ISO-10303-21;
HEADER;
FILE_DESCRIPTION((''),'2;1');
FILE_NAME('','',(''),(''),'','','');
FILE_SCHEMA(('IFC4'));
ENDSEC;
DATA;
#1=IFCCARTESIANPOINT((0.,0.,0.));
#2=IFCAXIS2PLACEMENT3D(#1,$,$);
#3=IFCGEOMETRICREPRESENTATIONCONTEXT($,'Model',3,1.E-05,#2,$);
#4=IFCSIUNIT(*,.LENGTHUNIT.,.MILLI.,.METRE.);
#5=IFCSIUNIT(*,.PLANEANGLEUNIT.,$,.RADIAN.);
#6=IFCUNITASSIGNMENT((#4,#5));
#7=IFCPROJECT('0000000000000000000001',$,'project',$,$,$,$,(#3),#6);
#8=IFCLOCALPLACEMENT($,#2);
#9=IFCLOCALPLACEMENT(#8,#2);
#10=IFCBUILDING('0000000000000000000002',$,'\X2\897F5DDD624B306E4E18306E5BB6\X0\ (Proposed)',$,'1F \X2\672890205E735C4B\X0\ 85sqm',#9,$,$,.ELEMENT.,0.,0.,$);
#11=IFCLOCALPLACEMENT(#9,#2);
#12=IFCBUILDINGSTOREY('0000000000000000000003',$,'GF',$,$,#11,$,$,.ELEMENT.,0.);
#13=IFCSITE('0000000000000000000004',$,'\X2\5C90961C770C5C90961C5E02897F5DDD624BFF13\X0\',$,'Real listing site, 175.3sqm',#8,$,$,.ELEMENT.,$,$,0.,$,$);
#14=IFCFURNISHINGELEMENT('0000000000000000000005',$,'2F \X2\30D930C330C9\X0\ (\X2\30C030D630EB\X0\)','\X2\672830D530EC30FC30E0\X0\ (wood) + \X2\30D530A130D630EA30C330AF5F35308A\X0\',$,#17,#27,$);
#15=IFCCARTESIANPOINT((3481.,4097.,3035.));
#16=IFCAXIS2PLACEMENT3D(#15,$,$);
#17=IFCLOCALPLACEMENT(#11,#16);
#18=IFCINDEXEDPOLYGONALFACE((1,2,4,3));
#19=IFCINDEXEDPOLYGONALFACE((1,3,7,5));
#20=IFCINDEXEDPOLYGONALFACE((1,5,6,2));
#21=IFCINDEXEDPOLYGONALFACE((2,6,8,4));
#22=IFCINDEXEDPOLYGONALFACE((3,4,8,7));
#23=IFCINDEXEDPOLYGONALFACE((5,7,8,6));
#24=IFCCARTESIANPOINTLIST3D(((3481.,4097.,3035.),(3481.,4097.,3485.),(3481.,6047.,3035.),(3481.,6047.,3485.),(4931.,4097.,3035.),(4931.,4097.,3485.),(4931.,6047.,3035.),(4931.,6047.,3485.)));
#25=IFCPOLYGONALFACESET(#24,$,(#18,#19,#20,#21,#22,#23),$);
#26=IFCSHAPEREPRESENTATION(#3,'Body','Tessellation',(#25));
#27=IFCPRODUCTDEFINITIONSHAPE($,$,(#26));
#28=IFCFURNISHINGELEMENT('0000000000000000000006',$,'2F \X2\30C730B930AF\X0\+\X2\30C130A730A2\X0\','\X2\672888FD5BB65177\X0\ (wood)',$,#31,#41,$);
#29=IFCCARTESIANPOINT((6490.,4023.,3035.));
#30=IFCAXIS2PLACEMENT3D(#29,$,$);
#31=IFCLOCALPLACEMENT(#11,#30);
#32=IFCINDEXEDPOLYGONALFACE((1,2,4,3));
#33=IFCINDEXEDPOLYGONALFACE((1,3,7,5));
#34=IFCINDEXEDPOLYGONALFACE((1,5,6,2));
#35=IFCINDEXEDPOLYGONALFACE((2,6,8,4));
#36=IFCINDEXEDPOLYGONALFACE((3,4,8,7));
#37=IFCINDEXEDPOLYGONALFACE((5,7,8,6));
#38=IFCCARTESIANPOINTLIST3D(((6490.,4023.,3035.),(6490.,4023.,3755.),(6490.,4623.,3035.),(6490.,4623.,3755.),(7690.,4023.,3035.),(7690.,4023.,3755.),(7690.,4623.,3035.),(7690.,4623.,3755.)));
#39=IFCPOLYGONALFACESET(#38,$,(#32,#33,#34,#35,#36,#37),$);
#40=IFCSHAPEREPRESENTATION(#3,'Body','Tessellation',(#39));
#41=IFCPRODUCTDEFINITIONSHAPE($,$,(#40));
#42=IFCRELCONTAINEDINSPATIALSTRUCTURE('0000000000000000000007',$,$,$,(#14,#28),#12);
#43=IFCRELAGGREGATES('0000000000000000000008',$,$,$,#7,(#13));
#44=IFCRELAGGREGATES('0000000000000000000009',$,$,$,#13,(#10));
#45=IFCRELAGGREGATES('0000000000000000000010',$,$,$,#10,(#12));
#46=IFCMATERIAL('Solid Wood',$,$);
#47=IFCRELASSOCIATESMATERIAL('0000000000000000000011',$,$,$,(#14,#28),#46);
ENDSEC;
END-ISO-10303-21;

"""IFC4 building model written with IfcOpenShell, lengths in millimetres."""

from ifc_helpers import new_model, si_unit, frame, frame_2d, origin, place, context, project, spatial, rectangle, extrude, material, element, save


model = new_model("IFC4")

# Units and contexts
model_context = context("Model", 3, precision=1e-05, world=origin())
ifc_project = project(units=[si_unit("LENGTHUNIT", "METRE", prefix="MILLI"), si_unit("PLANEANGLEUNIT", "RADIAN")], contexts=[model_context])

# Site, building, storey
site_placement = place(None, origin())
site = spatial("IfcSite", under=ifc_project, at=site_placement, Name="岐阜県岐阜市西川手３", ObjectType="Real listing site, 175.3sqm", CompositionType="ELEMENT", RefElevation=0.0)
building_placement = place(site_placement, origin())
building = spatial("IfcBuilding", under=site, at=building_placement, Name="西川手の丘の家 (Proposed)", ObjectType="1F 木造平屋 85sqm", CompositionType="ELEMENT", ElevationOfRefHeight=0.0, ElevationOfTerrain=0.0)
storey_placement = place(building_placement, origin())
storey = spatial("IfcBuildingStorey", under=building, at=storey_placement, Name="GF", CompositionType="ELEMENT", Elevation=0.0)

# Shared definitions
ifc_material_1 = material(Name="Solid Wood")

# Furnishing elements
furnishing_1_placement = place(storey_placement, frame((3481.0, 4097.0, 3035.0)))
element("IfcFurnishingElement", 1, at=furnishing_1_placement, inside=storey, material=ifc_material_1, Name="2F ベッド (ダブル)", Description="木フレーム (wood) + ファブリック張り", context=model_context, shape_type="SweptSolid", body=[
    extrude(rectangle(XDim=1450.0, YDim=1950.0, at=frame_2d((725.0, 975.0))), frame((3481.0, 4097.0, 3035.0)), (0.0, 0.0, 1.0), 450.0),
])
furnishing_2_placement = place(storey_placement, frame((6490.0, 4023.0, 3035.0)))
element("IfcFurnishingElement", 2, at=furnishing_2_placement, inside=storey, material=ifc_material_1, Name="2F デスク+チェア", Description="木製家具 (wood)", context=model_context, shape_type="SweptSolid", body=[
    extrude(rectangle(XDim=1200.0, YDim=600.0, at=frame_2d((600.0, 300.0))), frame((6490.0, 4023.0, 3035.0)), (0.0, 0.0, 1.0), 720.0),
])

save(model, "model.ifc")
